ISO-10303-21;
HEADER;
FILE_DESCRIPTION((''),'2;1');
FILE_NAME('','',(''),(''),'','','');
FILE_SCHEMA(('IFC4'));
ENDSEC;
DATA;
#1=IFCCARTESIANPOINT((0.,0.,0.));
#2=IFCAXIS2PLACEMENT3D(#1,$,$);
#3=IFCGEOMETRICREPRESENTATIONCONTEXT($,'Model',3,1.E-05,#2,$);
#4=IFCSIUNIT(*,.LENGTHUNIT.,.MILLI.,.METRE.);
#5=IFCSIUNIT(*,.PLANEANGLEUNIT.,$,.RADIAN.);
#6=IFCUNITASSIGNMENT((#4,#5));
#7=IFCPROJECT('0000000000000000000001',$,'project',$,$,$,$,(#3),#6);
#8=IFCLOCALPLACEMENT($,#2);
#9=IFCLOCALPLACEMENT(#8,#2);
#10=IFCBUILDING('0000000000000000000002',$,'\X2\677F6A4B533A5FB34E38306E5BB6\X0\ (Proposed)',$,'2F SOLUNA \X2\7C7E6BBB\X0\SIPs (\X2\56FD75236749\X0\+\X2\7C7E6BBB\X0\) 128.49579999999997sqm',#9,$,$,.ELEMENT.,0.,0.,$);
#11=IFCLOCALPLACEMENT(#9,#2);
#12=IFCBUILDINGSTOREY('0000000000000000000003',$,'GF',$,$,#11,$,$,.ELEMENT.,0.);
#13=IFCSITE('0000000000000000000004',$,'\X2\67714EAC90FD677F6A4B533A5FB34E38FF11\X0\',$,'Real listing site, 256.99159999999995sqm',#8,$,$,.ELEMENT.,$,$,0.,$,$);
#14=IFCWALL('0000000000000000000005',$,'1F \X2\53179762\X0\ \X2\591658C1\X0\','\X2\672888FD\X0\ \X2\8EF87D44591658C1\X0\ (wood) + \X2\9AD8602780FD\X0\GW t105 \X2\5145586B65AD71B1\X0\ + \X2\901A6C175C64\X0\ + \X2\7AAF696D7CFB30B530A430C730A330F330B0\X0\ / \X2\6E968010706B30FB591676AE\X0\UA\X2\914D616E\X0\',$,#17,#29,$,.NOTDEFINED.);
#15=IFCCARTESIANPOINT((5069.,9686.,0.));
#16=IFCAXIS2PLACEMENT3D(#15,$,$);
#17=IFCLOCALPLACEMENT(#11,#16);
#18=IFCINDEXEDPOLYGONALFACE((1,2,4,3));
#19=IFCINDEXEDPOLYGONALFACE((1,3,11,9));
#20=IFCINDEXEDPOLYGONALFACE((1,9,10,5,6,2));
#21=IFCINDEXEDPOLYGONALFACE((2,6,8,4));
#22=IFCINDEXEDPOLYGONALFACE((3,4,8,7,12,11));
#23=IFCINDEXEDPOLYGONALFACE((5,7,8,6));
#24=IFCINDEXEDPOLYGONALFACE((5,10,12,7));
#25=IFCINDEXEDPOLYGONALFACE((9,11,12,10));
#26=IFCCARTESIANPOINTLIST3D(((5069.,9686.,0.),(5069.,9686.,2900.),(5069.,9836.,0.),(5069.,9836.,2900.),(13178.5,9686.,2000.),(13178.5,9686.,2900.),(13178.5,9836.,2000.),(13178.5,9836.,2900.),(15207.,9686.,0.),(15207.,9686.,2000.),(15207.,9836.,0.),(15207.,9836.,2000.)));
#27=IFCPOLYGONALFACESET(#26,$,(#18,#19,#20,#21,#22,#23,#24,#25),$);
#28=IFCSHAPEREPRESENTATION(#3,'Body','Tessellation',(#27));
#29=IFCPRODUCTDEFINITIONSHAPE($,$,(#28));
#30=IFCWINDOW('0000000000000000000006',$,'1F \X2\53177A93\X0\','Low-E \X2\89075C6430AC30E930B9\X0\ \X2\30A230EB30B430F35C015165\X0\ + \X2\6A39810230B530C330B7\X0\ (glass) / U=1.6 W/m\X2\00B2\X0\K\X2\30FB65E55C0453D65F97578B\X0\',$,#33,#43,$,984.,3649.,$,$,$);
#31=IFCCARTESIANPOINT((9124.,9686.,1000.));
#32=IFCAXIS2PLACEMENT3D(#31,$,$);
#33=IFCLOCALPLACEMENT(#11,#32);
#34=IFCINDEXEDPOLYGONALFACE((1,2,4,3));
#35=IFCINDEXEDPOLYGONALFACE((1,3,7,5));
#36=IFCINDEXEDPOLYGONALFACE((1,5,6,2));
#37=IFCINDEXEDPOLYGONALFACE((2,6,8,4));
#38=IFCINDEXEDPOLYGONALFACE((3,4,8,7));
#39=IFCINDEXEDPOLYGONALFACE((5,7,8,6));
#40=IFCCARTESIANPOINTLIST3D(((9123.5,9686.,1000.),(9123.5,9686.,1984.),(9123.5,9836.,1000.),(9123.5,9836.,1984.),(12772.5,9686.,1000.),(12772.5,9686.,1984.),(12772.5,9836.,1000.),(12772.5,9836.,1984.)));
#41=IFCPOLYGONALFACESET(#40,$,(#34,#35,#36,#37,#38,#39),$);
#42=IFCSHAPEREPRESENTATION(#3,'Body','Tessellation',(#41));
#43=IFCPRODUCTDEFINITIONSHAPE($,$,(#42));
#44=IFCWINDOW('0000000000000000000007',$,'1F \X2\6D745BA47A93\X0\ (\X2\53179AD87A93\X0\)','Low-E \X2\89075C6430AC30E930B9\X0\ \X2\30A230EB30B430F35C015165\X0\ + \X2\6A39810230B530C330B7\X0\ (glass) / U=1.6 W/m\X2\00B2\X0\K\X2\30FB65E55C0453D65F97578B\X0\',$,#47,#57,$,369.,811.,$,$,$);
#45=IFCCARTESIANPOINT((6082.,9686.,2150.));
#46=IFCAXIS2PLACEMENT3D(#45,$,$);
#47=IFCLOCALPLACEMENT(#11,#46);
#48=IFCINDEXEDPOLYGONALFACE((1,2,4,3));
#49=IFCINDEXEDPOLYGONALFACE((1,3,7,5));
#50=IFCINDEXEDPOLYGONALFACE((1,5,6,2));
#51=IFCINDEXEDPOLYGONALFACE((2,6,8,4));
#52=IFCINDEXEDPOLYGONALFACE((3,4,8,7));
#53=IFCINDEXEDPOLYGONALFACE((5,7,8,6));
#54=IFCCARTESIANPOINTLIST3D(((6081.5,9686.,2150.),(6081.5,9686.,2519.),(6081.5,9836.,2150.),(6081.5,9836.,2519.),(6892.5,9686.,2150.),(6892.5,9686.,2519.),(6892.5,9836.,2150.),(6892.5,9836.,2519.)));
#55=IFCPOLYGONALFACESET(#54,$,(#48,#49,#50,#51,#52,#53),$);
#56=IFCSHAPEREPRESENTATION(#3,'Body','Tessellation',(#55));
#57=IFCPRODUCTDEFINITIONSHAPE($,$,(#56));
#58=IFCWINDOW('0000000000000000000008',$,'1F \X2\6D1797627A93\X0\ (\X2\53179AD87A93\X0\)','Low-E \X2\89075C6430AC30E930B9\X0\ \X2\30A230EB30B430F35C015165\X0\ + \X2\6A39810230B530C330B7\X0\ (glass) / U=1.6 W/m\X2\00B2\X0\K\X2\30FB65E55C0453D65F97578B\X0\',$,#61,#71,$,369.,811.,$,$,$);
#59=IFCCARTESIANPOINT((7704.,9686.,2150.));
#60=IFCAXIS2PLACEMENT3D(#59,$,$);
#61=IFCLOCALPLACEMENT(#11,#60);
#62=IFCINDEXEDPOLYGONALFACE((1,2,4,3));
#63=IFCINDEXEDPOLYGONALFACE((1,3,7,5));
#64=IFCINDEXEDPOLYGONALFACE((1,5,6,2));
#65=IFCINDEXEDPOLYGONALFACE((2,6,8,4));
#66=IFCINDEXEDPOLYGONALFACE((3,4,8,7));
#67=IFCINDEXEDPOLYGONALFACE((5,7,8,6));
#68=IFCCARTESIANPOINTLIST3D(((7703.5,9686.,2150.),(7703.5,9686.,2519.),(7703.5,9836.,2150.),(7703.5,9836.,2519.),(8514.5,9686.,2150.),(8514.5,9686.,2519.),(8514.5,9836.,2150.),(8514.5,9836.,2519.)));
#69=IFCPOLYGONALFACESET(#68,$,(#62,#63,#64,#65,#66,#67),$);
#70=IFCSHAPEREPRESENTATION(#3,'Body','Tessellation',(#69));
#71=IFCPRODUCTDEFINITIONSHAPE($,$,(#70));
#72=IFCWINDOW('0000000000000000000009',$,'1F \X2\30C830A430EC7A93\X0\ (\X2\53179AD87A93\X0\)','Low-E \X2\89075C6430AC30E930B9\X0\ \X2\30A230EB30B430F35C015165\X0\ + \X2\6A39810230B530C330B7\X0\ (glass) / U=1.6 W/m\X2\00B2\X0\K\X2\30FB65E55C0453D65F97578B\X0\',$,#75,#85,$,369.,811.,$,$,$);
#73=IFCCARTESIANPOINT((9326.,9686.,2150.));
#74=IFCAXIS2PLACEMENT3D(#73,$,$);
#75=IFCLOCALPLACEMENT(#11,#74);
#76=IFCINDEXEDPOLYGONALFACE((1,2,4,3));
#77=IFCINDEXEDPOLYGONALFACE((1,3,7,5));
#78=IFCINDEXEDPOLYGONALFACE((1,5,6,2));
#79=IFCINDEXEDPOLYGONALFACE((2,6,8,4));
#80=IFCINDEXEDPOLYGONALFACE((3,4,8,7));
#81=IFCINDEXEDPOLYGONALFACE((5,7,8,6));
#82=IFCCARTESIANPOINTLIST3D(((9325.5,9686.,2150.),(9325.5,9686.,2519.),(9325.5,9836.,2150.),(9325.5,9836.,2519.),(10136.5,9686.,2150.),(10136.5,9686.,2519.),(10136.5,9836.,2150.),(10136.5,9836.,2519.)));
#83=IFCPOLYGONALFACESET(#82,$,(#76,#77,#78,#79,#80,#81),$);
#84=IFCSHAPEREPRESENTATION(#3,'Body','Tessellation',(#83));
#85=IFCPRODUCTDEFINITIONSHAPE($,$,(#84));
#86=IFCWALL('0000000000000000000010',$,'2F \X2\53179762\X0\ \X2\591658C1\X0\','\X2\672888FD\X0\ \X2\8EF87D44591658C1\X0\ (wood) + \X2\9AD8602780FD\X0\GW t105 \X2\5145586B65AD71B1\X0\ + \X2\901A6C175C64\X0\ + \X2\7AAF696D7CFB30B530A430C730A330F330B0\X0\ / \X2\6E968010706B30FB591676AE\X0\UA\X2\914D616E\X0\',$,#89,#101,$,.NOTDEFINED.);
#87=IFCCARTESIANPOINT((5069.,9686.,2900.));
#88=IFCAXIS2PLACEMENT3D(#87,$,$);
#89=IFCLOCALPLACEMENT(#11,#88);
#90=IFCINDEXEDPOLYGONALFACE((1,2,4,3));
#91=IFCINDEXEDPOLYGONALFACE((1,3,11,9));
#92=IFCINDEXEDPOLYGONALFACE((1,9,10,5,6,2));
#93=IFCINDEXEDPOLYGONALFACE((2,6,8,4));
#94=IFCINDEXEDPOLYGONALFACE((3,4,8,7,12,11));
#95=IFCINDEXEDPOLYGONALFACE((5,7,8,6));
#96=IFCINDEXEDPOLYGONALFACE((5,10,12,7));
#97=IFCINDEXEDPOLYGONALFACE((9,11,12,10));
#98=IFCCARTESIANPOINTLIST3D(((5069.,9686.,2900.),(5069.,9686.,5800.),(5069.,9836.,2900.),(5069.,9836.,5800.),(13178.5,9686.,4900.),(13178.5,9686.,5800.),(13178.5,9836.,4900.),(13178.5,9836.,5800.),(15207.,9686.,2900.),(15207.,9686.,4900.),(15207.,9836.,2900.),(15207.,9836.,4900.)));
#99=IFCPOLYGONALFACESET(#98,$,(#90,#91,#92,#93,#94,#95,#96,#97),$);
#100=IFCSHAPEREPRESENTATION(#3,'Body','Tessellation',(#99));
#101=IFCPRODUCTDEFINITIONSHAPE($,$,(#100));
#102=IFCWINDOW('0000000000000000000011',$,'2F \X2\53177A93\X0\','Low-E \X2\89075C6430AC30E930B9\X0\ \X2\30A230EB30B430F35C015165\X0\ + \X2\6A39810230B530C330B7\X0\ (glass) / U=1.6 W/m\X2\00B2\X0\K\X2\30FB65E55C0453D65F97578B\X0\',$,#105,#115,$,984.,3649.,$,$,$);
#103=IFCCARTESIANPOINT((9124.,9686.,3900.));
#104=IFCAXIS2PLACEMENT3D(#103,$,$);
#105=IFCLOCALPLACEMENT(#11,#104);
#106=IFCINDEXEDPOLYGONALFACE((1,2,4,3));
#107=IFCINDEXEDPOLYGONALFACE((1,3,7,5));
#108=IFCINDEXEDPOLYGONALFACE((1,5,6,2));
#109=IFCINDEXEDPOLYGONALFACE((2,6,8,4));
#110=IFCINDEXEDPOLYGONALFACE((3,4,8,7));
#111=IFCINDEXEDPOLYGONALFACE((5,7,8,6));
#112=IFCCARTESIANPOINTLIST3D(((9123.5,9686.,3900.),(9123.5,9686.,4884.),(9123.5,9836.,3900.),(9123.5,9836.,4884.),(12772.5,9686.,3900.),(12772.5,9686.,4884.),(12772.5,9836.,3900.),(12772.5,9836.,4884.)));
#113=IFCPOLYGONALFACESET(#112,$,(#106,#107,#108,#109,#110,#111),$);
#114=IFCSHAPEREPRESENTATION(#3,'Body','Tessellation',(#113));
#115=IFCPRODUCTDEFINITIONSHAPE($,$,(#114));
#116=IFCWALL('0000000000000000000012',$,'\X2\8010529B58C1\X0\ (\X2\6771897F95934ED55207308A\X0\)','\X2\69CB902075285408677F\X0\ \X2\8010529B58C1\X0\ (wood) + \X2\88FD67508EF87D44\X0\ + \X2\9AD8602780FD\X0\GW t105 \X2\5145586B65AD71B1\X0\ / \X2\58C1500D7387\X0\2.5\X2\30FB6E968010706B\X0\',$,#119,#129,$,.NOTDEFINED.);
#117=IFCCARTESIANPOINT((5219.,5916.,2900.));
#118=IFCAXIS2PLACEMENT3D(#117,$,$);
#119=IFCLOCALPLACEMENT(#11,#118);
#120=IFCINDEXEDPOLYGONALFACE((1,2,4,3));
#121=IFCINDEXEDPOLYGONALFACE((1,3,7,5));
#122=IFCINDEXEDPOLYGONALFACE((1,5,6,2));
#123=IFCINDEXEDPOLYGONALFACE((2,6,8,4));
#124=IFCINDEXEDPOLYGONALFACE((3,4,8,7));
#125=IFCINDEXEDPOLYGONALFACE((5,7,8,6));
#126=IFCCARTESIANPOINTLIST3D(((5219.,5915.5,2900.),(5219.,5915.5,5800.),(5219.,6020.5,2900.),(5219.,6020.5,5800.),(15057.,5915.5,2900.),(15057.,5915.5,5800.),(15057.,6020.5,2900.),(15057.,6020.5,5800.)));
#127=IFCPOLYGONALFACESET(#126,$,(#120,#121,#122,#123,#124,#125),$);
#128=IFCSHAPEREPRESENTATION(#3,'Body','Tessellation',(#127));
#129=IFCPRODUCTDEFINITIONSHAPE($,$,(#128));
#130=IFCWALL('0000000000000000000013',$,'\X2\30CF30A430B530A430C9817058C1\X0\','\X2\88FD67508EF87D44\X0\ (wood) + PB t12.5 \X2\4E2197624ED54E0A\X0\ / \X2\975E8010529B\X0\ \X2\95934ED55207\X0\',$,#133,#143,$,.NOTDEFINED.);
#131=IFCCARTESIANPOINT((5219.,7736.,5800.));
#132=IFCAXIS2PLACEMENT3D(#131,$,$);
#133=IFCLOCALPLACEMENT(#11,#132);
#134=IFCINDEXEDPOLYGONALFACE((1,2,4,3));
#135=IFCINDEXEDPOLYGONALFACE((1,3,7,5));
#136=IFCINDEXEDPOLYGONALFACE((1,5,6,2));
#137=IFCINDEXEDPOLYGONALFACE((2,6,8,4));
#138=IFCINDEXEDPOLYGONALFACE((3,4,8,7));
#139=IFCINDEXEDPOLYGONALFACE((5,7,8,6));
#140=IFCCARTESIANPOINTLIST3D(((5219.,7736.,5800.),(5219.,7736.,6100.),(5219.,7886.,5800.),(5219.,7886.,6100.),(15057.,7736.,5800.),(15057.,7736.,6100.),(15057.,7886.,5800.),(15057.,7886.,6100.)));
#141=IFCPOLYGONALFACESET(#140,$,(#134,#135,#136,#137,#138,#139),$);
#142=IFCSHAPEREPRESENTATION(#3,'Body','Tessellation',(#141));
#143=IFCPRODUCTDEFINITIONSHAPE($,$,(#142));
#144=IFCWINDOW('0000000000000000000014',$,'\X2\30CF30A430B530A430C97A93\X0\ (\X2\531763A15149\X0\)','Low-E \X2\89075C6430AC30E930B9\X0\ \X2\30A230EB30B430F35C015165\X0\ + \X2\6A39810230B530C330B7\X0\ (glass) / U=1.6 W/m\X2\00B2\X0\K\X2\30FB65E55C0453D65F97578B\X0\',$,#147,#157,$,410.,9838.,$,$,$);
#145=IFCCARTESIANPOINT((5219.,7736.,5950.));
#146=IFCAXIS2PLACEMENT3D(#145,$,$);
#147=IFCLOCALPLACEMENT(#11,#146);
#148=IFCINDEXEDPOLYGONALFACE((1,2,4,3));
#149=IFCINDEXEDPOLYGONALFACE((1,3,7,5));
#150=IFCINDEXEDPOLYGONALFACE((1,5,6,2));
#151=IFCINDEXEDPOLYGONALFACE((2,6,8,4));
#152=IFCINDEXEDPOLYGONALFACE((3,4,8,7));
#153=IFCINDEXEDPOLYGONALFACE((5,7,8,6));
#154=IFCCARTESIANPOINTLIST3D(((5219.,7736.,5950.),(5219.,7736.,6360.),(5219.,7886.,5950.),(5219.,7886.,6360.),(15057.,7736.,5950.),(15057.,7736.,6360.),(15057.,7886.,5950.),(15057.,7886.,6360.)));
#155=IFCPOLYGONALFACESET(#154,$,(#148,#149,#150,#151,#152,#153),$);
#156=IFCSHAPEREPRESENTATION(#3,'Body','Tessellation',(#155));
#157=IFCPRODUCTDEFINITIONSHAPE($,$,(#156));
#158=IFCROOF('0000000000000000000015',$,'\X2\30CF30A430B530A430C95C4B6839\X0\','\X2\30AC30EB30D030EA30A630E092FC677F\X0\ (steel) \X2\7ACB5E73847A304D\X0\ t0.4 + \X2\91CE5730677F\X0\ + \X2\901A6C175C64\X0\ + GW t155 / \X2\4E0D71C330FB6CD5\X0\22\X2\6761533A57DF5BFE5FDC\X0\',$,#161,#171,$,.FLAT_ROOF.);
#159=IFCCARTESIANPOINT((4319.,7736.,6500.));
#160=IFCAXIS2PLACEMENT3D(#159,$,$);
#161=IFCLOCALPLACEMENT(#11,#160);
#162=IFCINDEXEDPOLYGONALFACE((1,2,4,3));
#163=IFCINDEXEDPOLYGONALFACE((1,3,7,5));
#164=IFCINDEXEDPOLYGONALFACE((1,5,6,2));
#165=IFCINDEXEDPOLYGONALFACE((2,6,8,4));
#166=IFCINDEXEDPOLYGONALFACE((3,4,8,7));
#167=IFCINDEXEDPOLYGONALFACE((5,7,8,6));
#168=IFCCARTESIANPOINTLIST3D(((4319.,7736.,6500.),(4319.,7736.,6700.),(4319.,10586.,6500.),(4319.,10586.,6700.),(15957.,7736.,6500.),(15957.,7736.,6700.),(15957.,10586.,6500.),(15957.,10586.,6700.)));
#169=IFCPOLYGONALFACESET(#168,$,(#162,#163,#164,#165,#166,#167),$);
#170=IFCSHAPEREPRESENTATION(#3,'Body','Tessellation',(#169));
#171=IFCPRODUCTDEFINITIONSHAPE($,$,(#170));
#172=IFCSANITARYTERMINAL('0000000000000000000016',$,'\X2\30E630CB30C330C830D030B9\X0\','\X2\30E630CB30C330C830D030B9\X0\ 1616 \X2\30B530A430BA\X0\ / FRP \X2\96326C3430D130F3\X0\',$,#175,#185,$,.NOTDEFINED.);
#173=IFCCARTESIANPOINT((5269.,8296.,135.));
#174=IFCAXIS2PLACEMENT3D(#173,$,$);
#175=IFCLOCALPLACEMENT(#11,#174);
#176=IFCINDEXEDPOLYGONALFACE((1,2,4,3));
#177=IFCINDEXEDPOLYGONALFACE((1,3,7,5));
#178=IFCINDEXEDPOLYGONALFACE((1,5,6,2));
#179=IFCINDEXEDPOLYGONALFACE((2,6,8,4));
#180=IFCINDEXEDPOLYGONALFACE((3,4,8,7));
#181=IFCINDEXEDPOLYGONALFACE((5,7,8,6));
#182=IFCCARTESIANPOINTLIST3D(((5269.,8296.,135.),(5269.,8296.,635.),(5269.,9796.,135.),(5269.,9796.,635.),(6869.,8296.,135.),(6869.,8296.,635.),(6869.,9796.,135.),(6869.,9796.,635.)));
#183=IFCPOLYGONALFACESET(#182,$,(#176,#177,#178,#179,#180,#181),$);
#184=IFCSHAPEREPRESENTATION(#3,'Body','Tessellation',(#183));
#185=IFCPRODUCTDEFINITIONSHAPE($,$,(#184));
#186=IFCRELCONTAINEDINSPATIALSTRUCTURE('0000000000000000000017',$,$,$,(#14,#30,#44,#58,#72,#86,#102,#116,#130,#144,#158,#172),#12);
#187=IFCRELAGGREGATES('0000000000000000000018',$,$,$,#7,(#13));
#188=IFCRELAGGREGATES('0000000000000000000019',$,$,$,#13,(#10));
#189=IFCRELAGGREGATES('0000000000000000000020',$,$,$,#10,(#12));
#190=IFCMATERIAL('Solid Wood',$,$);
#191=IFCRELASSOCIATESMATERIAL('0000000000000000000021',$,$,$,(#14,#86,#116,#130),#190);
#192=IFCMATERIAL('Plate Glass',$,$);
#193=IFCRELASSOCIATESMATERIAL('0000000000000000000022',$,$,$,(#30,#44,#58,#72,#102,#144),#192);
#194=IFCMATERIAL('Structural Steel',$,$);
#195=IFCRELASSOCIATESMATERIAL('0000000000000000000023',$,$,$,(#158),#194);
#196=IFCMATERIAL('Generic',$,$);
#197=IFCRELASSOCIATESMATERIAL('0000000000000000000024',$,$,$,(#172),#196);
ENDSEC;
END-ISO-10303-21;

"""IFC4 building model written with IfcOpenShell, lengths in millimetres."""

from ifc_helpers import new_model, si_unit, frame, frame_2d, origin, place, context, project, spatial, rectangle, extrude, material, element, fill, save


model = new_model("IFC4")

# Units and contexts
model_context = context("Model", 3, precision=1e-05, world=origin())
ifc_project = project(units=[si_unit("LENGTHUNIT", "METRE", prefix="MILLI"), si_unit("PLANEANGLEUNIT", "RADIAN")], contexts=[model_context])

# Site, building, storey
site_placement = place(None, origin())
site = spatial("IfcSite", under=ifc_project, at=site_placement, Name="東京都板橋区徳丸１", ObjectType="Real listing site, 256.99159999999995sqm", CompositionType="ELEMENT", RefElevation=0.0)
building_placement = place(site_placement, origin())
building = spatial("IfcBuilding", under=site, at=building_placement, Name="板橋区徳丸の家 (Proposed)", ObjectType="2F SOLUNA 籾殻SIPs (国産杉+籾殻) 128.49579999999997sqm", CompositionType="ELEMENT", ElevationOfRefHeight=0.0, ElevationOfTerrain=0.0)
storey_placement = place(building_placement, origin())
storey = spatial("IfcBuildingStorey", under=building, at=storey_placement, Name="GF", CompositionType="ELEMENT", Elevation=0.0)

# Wall, openings, windows
ifc_material_1 = material(Name="Solid Wood")
wall_1_placement = place(storey_placement, frame((5069.0, 9686.0, 0.0)))
wall_1 = element("IfcWall", 1, at=wall_1_placement, inside=storey, material=ifc_material_1, Name="1F 北面 外壁", Description="木製 軸組外壁 (wood) + 高性能GW t105 充填断熱 + 通気層 + 窯業系サイディング / 準耐火・外皮UA配慮", PredefinedType="NOTDEFINED", context=model_context, shape_type="SweptSolid", body=[
    extrude(rectangle(XDim=10138.0, YDim=150.0, at=frame_2d((5069.0, 75.0))), frame((5069.0, 9686.0, 0.0)), (0.0, 0.0, 1.0), 2900.0),
])
opening_1_placement = place(storey_placement, frame((9124.0, 9686.0, 1000.0)))
opening_1 = element("IfcOpeningElement", 2, at=opening_1_placement, cuts=wall_1, PredefinedType="NOTDEFINED", context=model_context, shape_type="SweptSolid", body=[
    extrude(rectangle(XDim=3649.0, YDim=150.0, at=frame_2d((1824.0, 75.0))), frame((9124.0, 9686.0, 1000.0)), (0.0, 0.0, 1.0), 984.0),
])
opening_2_placement = place(storey_placement, frame((6082.0, 9686.0, 2150.0)))
opening_2 = element("IfcOpeningElement", 3, at=opening_2_placement, cuts=wall_1, PredefinedType="NOTDEFINED", context=model_context, shape_type="SweptSolid", body=[
    extrude(rectangle(XDim=811.0, YDim=150.0, at=frame_2d((405.0, 75.0))), frame((6082.0, 9686.0, 2150.0)), (0.0, 0.0, 1.0), 369.0),
])
opening_3_placement = place(storey_placement, frame((7704.0, 9686.0, 2150.0)))
opening_3 = element("IfcOpeningElement", 4, at=opening_3_placement, cuts=wall_1, PredefinedType="NOTDEFINED", context=model_context, shape_type="SweptSolid", body=[
    extrude(rectangle(XDim=811.0, YDim=150.0, at=frame_2d((405.0, 75.0))), frame((7704.0, 9686.0, 2150.0)), (0.0, 0.0, 1.0), 369.0),
])
opening_4_placement = place(storey_placement, frame((9326.0, 9686.0, 2150.0)))
opening_4 = element("IfcOpeningElement", 5, at=opening_4_placement, cuts=wall_1, PredefinedType="NOTDEFINED", context=model_context, shape_type="SweptSolid", body=[
    extrude(rectangle(XDim=811.0, YDim=150.0, at=frame_2d((405.0, 75.0))), frame((9326.0, 9686.0, 2150.0)), (0.0, 0.0, 1.0), 369.0),
])
ifc_material_2 = material(Name="Plate Glass")
window_1_placement = place(storey_placement, frame((9124.0, 9686.0, 1000.0)))
window_1 = element("IfcWindow", 6, at=window_1_placement, inside=storey, material=ifc_material_2, Name="1F 北窓", Description="Low-E 複層ガラス アルゴン封入 + 樹脂サッシ (glass) / U=1.6 W/m²K・日射取得型", OverallHeight=984.0, OverallWidth=3649.0, context=model_context, shape_type="SweptSolid", body=[
    extrude(rectangle(XDim=3649.0, YDim=150.0, at=frame_2d((1824.0, 75.0))), frame((9124.0, 9686.0, 1000.0)), (0.0, 0.0, 1.0), 984.0),
])
fill(opening_1, window_1)
window_2_placement = place(storey_placement, frame((6082.0, 9686.0, 2150.0)))
window_2 = element("IfcWindow", 7, at=window_2_placement, inside=storey, material=ifc_material_2, Name="1F 浴室窓 (北高窓)", Description="Low-E 複層ガラス アルゴン封入 + 樹脂サッシ (glass) / U=1.6 W/m²K・日射取得型", OverallHeight=369.0, OverallWidth=811.0, context=model_context, shape_type="SweptSolid", body=[
    extrude(rectangle(XDim=811.0, YDim=150.0, at=frame_2d((405.0, 75.0))), frame((6082.0, 9686.0, 2150.0)), (0.0, 0.0, 1.0), 369.0),
])
fill(opening_2, window_2)
window_3_placement = place(storey_placement, frame((7704.0, 9686.0, 2150.0)))
window_3 = element("IfcWindow", 8, at=window_3_placement, inside=storey, material=ifc_material_2, Name="1F 洗面窓 (北高窓)", Description="Low-E 複層ガラス アルゴン封入 + 樹脂サッシ (glass) / U=1.6 W/m²K・日射取得型", OverallHeight=369.0, OverallWidth=811.0, context=model_context, shape_type="SweptSolid", body=[
    extrude(rectangle(XDim=811.0, YDim=150.0, at=frame_2d((405.0, 75.0))), frame((7704.0, 9686.0, 2150.0)), (0.0, 0.0, 1.0), 369.0),
])
fill(opening_3, window_3)
window_4_placement = place(storey_placement, frame((9326.0, 9686.0, 2150.0)))
window_4 = element("IfcWindow", 9, at=window_4_placement, inside=storey, material=ifc_material_2, Name="1F トイレ窓 (北高窓)", Description="Low-E 複層ガラス アルゴン封入 + 樹脂サッシ (glass) / U=1.6 W/m²K・日射取得型", OverallHeight=369.0, OverallWidth=811.0, context=model_context, shape_type="SweptSolid", body=[
    extrude(rectangle(XDim=811.0, YDim=150.0, at=frame_2d((405.0, 75.0))), frame((9326.0, 9686.0, 2150.0)), (0.0, 0.0, 1.0), 369.0),
])
fill(opening_4, window_4)

# Wall, opening, window
wall_2_placement = place(storey_placement, frame((5069.0, 9686.0, 2900.0)))
wall_2 = element("IfcWall", 10, at=wall_2_placement, inside=storey, material=ifc_material_1, Name="2F 北面 外壁", Description="木製 軸組外壁 (wood) + 高性能GW t105 充填断熱 + 通気層 + 窯業系サイディング / 準耐火・外皮UA配慮", PredefinedType="NOTDEFINED", context=model_context, shape_type="SweptSolid", body=[
    extrude(rectangle(XDim=10138.0, YDim=150.0, at=frame_2d((5069.0, 75.0))), frame((5069.0, 9686.0, 2900.0)), (0.0, 0.0, 1.0), 2900.0),
])
opening_5_placement = place(storey_placement, frame((9124.0, 9686.0, 3900.0)))
opening_5 = element("IfcOpeningElement", 11, at=opening_5_placement, cuts=wall_2, PredefinedType="NOTDEFINED", context=model_context, shape_type="SweptSolid", body=[
    extrude(rectangle(XDim=3649.0, YDim=150.0, at=frame_2d((1824.0, 75.0))), frame((9124.0, 9686.0, 3900.0)), (0.0, 0.0, 1.0), 984.0),
])
window_5_placement = place(storey_placement, frame((9124.0, 9686.0, 3900.0)))
window_5 = element("IfcWindow", 12, at=window_5_placement, inside=storey, material=ifc_material_2, Name="2F 北窓", Description="Low-E 複層ガラス アルゴン封入 + 樹脂サッシ (glass) / U=1.6 W/m²K・日射取得型", OverallHeight=984.0, OverallWidth=3649.0, context=model_context, shape_type="SweptSolid", body=[
    extrude(rectangle(XDim=3649.0, YDim=150.0, at=frame_2d((1824.0, 75.0))), frame((9124.0, 9686.0, 3900.0)), (0.0, 0.0, 1.0), 984.0),
])
fill(opening_5, window_5)

# Wall
wall_3_placement = place(storey_placement, frame((5219.0, 5916.0, 2900.0)))
element("IfcWall", 13, at=wall_3_placement, inside=storey, material=ifc_material_1, Name="耐力壁 (東西間仕切り)", Description="構造用合板 耐力壁 (wood) + 製材軸組 + 高性能GW t105 充填断熱 / 壁倍率2.5・準耐火", PredefinedType="NOTDEFINED", context=model_context, shape_type="SweptSolid", body=[
    extrude(rectangle(XDim=9838.0, YDim=105.0, at=frame_2d((4919.0, 52.0))), frame((5219.0, 5916.0, 2900.0)), (0.0, 0.0, 1.0), 2900.0),
])

# Wall, opening, window
wall_4_placement = place(storey_placement, frame((5219.0, 7736.0, 5800.0)))
wall_4 = element("IfcWall", 14, at=wall_4_placement, inside=storey, material=ifc_material_1, Name="ハイサイド腰壁", Description="製材軸組 (wood) + PB t12.5 両面仕上 / 非耐力 間仕切", PredefinedType="NOTDEFINED", context=model_context, shape_type="SweptSolid", body=[
    extrude(rectangle(XDim=9838.0, YDim=150.0, at=frame_2d((4919.0, 75.0))), frame((5219.0, 7736.0, 5800.0)), (0.0, 0.0, 1.0), 700.0),
])
opening_6_placement = place(storey_placement, frame((5219.0, 7736.0, 5950.0)))
opening_6 = element("IfcOpeningElement", 15, at=opening_6_placement, cuts=wall_4, PredefinedType="NOTDEFINED", context=model_context, shape_type="SweptSolid", body=[
    extrude(rectangle(XDim=9838.0, YDim=150.0, at=frame_2d((4919.0, 75.0))), frame((5219.0, 7736.0, 5950.0)), (0.0, 0.0, 1.0), 410.0),
])
window_6_placement = place(storey_placement, frame((5219.0, 7736.0, 5950.0)))
window_6 = element("IfcWindow", 16, at=window_6_placement, inside=storey, material=ifc_material_2, Name="ハイサイド窓 (北採光)", Description="Low-E 複層ガラス アルゴン封入 + 樹脂サッシ (glass) / U=1.6 W/m²K・日射取得型", OverallHeight=410.0, OverallWidth=9838.0, context=model_context, shape_type="SweptSolid", body=[
    extrude(rectangle(XDim=9838.0, YDim=150.0, at=frame_2d((4919.0, 75.0))), frame((5219.0, 7736.0, 5950.0)), (0.0, 0.0, 1.0), 410.0),
])
fill(opening_6, window_6)

# Roof
ifc_material_3 = material(Name="Structural Steel")
roof_placement = place(storey_placement, frame((4319.0, 7736.0, 6500.0)))
element("IfcRoof", 17, at=roof_placement, inside=storey, material=ifc_material_3, Name="ハイサイド屋根", Description="ガルバリウム鋼板 (steel) 立平葺き t0.4 + 野地板 + 通気層 + GW t155 / 不燃・法22条区域対応", PredefinedType="FLAT_ROOF", context=model_context, shape_type="SweptSolid", body=[
    extrude(rectangle(XDim=11638.0, YDim=2850.0, at=frame_2d((5819.0, 1425.0))), frame((4319.0, 7736.0, 6500.0)), (0.0, 0.0, 1.0), 200.0),
])

# Sanitary terminal
ifc_material_4 = material(Name="Generic")
sanitary_terminal_placement = place(storey_placement, frame((5269.0, 8296.0, 135.0)))
element("IfcSanitaryTerminal", 18, at=sanitary_terminal_placement, inside=storey, material=ifc_material_4, Name="ユニットバス", Description="ユニットバス 1616 サイズ / FRP 防水パン", PredefinedType="NOTDEFINED", context=model_context, shape_type="SweptSolid", body=[
    extrude(rectangle(XDim=1600.0, YDim=1500.0, at=frame_2d((800.0, 750.0))), frame((5269.0, 8296.0, 135.0)), (0.0, 0.0, 1.0), 500.0),
])

save(model, "model.ifc")
